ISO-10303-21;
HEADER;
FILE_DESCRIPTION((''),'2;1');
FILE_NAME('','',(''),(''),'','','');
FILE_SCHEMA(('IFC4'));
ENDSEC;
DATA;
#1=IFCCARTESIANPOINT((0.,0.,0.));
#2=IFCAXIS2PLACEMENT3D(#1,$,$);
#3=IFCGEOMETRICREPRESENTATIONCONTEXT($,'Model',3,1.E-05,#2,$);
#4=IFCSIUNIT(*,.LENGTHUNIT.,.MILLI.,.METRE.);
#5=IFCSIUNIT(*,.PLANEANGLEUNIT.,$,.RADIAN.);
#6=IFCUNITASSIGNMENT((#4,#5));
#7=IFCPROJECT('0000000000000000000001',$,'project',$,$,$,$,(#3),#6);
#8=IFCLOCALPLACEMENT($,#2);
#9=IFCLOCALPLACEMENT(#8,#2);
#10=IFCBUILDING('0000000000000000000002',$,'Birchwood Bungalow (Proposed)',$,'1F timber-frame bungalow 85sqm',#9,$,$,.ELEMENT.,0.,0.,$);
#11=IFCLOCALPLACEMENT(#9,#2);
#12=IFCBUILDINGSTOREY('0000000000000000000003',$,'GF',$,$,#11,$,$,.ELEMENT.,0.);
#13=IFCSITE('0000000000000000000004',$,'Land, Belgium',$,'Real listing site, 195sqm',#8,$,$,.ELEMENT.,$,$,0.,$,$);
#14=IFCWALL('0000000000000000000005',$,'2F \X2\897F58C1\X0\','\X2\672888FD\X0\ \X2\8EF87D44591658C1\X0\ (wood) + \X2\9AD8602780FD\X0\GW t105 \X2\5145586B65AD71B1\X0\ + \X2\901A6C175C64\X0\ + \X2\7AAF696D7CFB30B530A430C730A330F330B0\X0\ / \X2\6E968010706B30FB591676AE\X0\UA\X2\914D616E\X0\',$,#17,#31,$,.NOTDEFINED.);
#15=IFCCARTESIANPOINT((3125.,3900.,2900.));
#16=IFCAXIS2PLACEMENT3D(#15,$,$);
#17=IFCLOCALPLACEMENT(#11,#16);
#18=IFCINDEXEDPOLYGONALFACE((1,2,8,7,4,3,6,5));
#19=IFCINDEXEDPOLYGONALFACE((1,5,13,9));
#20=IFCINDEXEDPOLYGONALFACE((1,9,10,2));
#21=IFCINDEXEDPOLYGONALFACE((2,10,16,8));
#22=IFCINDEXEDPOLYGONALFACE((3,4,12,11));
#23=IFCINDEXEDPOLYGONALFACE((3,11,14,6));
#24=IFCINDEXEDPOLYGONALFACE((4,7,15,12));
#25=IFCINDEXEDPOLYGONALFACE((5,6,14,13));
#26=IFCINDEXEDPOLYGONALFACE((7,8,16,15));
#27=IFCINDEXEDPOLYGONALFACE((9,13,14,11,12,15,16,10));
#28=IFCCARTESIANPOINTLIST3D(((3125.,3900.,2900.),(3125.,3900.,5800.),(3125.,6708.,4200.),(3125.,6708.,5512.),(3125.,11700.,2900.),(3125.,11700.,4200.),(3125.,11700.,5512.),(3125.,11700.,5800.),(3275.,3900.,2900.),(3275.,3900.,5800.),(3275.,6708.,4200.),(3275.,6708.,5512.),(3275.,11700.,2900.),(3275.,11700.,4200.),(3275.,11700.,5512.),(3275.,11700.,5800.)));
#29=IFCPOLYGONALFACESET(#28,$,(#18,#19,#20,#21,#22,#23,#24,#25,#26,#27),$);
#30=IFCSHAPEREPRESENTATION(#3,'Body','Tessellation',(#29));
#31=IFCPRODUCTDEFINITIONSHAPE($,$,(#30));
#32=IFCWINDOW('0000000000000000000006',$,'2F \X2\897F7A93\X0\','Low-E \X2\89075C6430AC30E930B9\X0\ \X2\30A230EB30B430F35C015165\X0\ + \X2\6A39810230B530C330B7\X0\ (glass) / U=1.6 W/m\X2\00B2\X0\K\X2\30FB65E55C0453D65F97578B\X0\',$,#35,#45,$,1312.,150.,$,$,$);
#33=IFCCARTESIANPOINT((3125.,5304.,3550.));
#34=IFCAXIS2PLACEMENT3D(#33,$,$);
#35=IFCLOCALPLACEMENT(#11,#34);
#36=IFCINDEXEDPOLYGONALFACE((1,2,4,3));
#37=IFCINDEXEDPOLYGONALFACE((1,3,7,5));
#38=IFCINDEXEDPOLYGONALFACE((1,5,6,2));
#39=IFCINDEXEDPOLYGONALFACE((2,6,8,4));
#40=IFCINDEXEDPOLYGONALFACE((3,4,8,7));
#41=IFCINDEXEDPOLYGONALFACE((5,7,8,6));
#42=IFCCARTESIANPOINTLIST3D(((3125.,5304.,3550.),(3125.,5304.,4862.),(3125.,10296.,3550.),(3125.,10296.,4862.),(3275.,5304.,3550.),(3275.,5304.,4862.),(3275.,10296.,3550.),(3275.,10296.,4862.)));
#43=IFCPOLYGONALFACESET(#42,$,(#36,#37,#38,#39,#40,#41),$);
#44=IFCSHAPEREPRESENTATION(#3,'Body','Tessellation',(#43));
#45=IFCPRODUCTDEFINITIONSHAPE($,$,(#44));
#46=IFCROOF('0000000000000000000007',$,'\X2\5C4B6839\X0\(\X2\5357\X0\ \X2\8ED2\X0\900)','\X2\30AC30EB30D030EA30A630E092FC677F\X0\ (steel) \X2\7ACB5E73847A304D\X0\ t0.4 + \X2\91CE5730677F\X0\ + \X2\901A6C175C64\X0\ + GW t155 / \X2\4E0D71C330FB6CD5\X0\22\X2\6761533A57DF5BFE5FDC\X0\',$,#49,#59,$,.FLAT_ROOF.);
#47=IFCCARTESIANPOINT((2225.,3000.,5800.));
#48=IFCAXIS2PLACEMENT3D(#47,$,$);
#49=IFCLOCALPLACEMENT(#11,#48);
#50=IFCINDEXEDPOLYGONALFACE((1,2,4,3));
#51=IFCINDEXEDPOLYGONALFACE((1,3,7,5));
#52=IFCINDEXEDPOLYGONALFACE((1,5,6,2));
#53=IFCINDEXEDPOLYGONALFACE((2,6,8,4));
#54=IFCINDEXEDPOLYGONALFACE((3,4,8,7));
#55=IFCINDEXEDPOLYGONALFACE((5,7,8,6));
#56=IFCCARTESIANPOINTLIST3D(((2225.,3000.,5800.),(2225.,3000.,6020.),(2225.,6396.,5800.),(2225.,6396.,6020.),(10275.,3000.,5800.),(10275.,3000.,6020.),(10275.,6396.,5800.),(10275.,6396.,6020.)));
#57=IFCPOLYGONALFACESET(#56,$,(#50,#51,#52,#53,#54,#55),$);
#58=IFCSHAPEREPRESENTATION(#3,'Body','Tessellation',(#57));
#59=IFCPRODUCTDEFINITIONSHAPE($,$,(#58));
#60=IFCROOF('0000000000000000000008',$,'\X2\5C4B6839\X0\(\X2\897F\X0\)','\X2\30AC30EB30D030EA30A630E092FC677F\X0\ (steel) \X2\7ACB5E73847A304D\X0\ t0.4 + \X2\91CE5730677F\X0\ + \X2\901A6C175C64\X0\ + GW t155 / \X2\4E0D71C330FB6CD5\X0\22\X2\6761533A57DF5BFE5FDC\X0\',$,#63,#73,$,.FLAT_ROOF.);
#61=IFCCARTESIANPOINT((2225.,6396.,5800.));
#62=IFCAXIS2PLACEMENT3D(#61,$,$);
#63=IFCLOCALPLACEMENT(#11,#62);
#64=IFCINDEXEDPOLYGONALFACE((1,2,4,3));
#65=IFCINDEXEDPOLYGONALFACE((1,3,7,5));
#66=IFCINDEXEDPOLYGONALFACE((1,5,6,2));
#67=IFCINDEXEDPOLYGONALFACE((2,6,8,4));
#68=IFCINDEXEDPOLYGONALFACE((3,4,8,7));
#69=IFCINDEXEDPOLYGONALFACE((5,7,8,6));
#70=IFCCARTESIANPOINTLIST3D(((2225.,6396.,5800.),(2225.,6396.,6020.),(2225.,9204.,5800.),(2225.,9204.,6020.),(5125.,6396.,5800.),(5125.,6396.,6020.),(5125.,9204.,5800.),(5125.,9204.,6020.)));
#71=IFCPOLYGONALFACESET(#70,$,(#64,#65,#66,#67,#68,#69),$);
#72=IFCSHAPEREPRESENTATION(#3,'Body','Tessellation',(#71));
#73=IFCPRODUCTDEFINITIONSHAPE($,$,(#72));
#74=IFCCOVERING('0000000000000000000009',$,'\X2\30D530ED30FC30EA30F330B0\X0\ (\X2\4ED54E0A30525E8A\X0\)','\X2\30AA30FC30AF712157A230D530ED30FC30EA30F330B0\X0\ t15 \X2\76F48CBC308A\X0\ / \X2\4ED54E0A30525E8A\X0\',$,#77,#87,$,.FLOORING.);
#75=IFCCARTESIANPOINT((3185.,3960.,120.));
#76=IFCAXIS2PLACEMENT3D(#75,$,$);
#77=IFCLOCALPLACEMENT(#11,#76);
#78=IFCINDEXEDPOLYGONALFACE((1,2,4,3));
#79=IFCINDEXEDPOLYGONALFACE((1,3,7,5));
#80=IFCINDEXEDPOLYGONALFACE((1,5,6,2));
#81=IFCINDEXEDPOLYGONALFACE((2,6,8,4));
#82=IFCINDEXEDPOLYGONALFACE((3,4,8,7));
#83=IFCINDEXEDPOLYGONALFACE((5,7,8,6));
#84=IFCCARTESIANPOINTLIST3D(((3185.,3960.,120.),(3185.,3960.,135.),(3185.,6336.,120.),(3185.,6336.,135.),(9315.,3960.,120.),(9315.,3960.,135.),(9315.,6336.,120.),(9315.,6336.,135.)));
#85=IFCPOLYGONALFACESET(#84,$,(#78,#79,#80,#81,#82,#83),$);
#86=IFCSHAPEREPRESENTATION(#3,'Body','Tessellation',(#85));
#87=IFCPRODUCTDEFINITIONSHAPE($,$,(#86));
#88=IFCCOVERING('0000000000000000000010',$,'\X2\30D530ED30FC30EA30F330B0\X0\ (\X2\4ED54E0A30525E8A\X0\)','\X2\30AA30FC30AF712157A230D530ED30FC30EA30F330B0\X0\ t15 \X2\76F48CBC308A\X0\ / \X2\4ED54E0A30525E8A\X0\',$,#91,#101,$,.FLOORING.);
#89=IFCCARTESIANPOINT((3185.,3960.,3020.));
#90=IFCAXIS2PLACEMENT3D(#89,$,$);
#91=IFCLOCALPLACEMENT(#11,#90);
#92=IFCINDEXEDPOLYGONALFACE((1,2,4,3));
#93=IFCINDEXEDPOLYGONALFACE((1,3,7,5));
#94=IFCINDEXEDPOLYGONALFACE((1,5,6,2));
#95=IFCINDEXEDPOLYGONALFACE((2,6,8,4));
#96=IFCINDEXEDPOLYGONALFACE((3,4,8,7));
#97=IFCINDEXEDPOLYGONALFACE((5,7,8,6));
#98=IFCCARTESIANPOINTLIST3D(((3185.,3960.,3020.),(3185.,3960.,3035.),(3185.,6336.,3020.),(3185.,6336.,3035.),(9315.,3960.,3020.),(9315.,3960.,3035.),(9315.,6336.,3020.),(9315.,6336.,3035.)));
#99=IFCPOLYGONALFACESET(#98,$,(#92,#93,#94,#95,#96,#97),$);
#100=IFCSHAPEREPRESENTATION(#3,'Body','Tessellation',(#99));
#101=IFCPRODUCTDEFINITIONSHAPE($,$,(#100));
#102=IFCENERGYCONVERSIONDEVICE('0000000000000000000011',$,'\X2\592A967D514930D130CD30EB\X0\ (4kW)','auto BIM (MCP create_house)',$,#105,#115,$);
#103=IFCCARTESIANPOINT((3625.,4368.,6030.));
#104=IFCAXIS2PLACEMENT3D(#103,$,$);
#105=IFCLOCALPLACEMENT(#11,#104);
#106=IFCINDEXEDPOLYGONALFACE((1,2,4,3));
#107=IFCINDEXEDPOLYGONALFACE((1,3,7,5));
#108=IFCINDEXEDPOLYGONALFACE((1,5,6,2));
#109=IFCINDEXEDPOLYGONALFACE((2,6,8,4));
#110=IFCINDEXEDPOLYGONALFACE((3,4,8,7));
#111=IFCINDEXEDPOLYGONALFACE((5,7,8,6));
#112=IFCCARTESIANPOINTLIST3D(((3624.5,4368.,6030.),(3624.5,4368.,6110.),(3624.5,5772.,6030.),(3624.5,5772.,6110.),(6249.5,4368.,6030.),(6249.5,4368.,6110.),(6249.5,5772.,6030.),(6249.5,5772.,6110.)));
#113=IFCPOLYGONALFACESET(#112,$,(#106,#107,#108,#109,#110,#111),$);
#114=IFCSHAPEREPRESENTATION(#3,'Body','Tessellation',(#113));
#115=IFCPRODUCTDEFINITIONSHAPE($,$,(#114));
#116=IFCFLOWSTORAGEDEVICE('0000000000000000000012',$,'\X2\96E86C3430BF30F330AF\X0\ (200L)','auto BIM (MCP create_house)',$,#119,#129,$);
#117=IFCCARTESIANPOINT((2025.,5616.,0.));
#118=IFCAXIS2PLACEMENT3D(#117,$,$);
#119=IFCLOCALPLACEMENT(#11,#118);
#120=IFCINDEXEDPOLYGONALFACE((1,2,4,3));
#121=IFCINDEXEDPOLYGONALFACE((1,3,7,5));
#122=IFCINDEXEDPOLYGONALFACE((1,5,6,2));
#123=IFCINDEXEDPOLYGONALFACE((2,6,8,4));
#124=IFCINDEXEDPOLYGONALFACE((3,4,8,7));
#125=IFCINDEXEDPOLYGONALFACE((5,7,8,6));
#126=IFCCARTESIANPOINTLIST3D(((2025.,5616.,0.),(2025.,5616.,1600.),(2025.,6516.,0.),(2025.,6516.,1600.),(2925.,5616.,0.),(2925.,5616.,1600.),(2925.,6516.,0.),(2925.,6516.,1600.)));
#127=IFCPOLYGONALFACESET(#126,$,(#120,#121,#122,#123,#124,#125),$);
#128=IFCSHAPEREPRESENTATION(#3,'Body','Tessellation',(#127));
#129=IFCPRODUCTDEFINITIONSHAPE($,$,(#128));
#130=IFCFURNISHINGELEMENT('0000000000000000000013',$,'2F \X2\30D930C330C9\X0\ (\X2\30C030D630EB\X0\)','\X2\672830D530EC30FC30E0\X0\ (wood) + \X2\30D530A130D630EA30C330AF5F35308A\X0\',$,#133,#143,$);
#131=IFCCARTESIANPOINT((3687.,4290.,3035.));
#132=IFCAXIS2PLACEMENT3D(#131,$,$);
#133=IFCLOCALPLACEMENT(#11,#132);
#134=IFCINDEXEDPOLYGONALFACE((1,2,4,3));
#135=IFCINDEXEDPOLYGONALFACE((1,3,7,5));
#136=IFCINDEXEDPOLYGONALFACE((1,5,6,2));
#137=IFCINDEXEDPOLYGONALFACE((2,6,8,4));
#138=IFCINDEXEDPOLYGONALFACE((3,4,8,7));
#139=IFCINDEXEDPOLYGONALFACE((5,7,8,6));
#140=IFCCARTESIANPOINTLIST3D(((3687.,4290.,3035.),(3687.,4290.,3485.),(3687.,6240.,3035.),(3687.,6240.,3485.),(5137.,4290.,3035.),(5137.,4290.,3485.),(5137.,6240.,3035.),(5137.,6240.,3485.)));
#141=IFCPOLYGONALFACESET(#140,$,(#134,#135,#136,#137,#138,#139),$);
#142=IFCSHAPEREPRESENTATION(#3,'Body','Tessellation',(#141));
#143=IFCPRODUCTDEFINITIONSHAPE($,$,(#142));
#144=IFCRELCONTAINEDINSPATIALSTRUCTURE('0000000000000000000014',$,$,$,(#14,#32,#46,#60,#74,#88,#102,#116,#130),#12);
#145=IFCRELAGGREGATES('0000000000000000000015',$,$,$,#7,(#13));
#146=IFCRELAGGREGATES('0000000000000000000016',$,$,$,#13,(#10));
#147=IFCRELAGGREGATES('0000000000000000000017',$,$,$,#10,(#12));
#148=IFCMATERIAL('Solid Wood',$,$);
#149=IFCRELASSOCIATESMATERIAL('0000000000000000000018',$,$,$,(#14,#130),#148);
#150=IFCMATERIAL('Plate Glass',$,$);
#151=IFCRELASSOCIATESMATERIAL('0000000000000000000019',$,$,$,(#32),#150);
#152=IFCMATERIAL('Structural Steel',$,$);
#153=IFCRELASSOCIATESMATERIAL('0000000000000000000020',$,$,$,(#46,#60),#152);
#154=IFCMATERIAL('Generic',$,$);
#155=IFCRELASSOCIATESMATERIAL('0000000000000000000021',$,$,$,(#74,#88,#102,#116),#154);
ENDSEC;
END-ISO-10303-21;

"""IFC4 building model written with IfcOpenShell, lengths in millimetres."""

from ifc_helpers import new_model, si_unit, frame, frame_2d, origin, place, context, project, spatial, rectangle, extrude, material, element, fill, save


model = new_model("IFC4")

# Units and contexts
model_context = context("Model", 3, precision=1e-05, world=origin())
ifc_project = project(units=[si_unit("LENGTHUNIT", "METRE", prefix="MILLI"), si_unit("PLANEANGLEUNIT", "RADIAN")], contexts=[model_context])

# Site, building, storey
site_placement = place(None, origin())
site = spatial("IfcSite", under=ifc_project, at=site_placement, Name="Land, Belgium", ObjectType="Real listing site, 195sqm", CompositionType="ELEMENT", RefElevation=0.0)
building_placement = place(site_placement, origin())
building = spatial("IfcBuilding", under=site, at=building_placement, Name="Birchwood Bungalow (Proposed)", ObjectType="1F timber-frame bungalow 85sqm", CompositionType="ELEMENT", ElevationOfRefHeight=0.0, ElevationOfTerrain=0.0)
storey_placement = place(building_placement, origin())
storey = spatial("IfcBuildingStorey", under=building, at=storey_placement, Name="GF", CompositionType="ELEMENT", Elevation=0.0)

# Shared definitions
ifc_material_1 = material(Name="Solid Wood")
ifc_material_2 = material(Name="Generic")

# Shared definitions
ifc_material_3 = material(Name="Plate Glass")

# Wall, opening, window
wall_1_placement = place(storey_placement, frame((3125.0, 3900.0, 2900.0)))
wall_1 = element("IfcWall", 1, at=wall_1_placement, inside=storey, material=ifc_material_1, Name="2F 西壁", Description="木製 軸組外壁 (wood) + 高性能GW t105 充填断熱 + 通気層 + 窯業系サイディング / 準耐火・外皮UA配慮", PredefinedType="NOTDEFINED", context=model_context, shape_type="SweptSolid", body=[
    extrude(rectangle(XDim=150.0, YDim=7800.0, at=frame_2d((75.0, 3900.0))), frame((3125.0, 3900.0, 2900.0)), (0.0, 0.0, 1.0), 2900.0),
])
opening_1_placement = place(storey_placement, frame((3125.0, 5304.0, 3550.0)))
opening_1 = element("IfcOpeningElement", 2, at=opening_1_placement, cuts=wall_1, PredefinedType="NOTDEFINED", context=model_context, shape_type="SweptSolid", body=[
    extrude(rectangle(XDim=150.0, YDim=4992.0, at=frame_2d((75.0, 2496.0))), frame((3125.0, 5304.0, 3550.0)), (0.0, 0.0, 1.0), 1312.0),
])
window_1_placement = place(storey_placement, frame((3125.0, 5304.0, 3550.0)))
window_1 = element("IfcWindow", 3, at=window_1_placement, inside=storey, material=ifc_material_3, Name="2F 西窓", Description="Low-E 複層ガラス アルゴン封入 + 樹脂サッシ (glass) / U=1.6 W/m²K・日射取得型", OverallHeight=1312.0, OverallWidth=150.0, context=model_context, shape_type="SweptSolid", body=[
    extrude(rectangle(XDim=150.0, YDim=4992.0, at=frame_2d((75.0, 2496.0))), frame((3125.0, 5304.0, 3550.0)), (0.0, 0.0, 1.0), 1312.0),
])
fill(opening_1, window_1)

# Roofs
ifc_material_4 = material(Name="Structural Steel")
roof_1_placement = place(storey_placement, frame((2225.0, 3000.0, 5800.0)))
element("IfcRoof", 4, at=roof_1_placement, inside=storey, material=ifc_material_4, Name="屋根(南 軒900)", Description="ガルバリウム鋼板 (steel) 立平葺き t0.4 + 野地板 + 通気層 + GW t155 / 不燃・法22条区域対応", PredefinedType="FLAT_ROOF", context=model_context, shape_type="SweptSolid", body=[
    extrude(rectangle(XDim=8050.0, YDim=3396.0, at=frame_2d((4025.0, 1698.0))), frame((2225.0, 3000.0, 5800.0)), (0.0, 0.0, 1.0), 220.0),
])
roof_2_placement = place(storey_placement, frame((2225.0, 6396.0, 5800.0)))
element("IfcRoof", 5, at=roof_2_placement, inside=storey, material=ifc_material_4, Name="屋根(西)", Description="ガルバリウム鋼板 (steel) 立平葺き t0.4 + 野地板 + 通気層 + GW t155 / 不燃・法22条区域対応", PredefinedType="FLAT_ROOF", context=model_context, shape_type="SweptSolid", body=[
    extrude(rectangle(XDim=2900.0, YDim=2808.0, at=frame_2d((1450.0, 1404.0))), frame((2225.0, 6396.0, 5800.0)), (0.0, 0.0, 1.0), 220.0),
])

# Coverings
covering_1_placement = place(storey_placement, frame((3185.0, 3960.0, 120.0)))
element("IfcCovering", 6, at=covering_1_placement, inside=storey, material=ifc_material_2, Name="フローリング (仕上げ床)", Description="オーク無垢フローリング t15 直貼り / 仕上げ床", PredefinedType="FLOORING", context=model_context, shape_type="SweptSolid", body=[
    extrude(rectangle(XDim=6130.0, YDim=2376.0, at=frame_2d((3065.0, 1188.0))), frame((3185.0, 3960.0, 120.0)), (0.0, 0.0, 1.0), 15.0),
])
covering_2_placement = place(storey_placement, frame((3185.0, 3960.0, 3020.0)))
element("IfcCovering", 7, at=covering_2_placement, inside=storey, material=ifc_material_2, Name="フローリング (仕上げ床)", Description="オーク無垢フローリング t15 直貼り / 仕上げ床", PredefinedType="FLOORING", context=model_context, shape_type="SweptSolid", body=[
    extrude(rectangle(XDim=6130.0, YDim=2376.0, at=frame_2d((3065.0, 1188.0))), frame((3185.0, 3960.0, 3020.0)), (0.0, 0.0, 1.0), 15.0),
])

# Energy conversion device
energy_conversion_device_placement = place(storey_placement, frame((3625.0, 4368.0, 6030.0)))
element("IfcEnergyConversionDevice", 8, at=energy_conversion_device_placement, inside=storey, material=ifc_material_2, Name="太陽光パネル (4kW)", Description="auto BIM (MCP create_house)", context=model_context, shape_type="SweptSolid", body=[
    extrude(rectangle(XDim=2625.0, YDim=1404.0, at=frame_2d((1312.0, 702.0))), frame((3625.0, 4368.0, 6030.0)), (0.0, 0.0, 1.0), 80.0),
])

# Flow storage device
flow_storage_device_placement = place(storey_placement, frame((2025.0, 5616.0, 0.0)))
element("IfcFlowStorageDevice", 9, at=flow_storage_device_placement, inside=storey, material=ifc_material_2, Name="雨水タンク (200L)", Description="auto BIM (MCP create_house)", context=model_context, shape_type="SweptSolid", body=[
    extrude(rectangle(XDim=900.0, YDim=900.0, at=frame_2d((450.0, 450.0))), frame((2025.0, 5616.0, 0.0)), (0.0, 0.0, 1.0), 1600.0),
])

# Furnishing element
furnishing_placement = place(storey_placement, frame((3687.0, 4290.0, 3035.0)))
element("IfcFurnishingElement", 10, at=furnishing_placement, inside=storey, material=ifc_material_1, Name="2F ベッド (ダブル)", Description="木フレーム (wood) + ファブリック張り", context=model_context, shape_type="SweptSolid", body=[
    extrude(rectangle(XDim=1450.0, YDim=1950.0, at=frame_2d((725.0, 975.0))), frame((3687.0, 4290.0, 3035.0)), (0.0, 0.0, 1.0), 450.0),
])

save(model, "model.ifc")
